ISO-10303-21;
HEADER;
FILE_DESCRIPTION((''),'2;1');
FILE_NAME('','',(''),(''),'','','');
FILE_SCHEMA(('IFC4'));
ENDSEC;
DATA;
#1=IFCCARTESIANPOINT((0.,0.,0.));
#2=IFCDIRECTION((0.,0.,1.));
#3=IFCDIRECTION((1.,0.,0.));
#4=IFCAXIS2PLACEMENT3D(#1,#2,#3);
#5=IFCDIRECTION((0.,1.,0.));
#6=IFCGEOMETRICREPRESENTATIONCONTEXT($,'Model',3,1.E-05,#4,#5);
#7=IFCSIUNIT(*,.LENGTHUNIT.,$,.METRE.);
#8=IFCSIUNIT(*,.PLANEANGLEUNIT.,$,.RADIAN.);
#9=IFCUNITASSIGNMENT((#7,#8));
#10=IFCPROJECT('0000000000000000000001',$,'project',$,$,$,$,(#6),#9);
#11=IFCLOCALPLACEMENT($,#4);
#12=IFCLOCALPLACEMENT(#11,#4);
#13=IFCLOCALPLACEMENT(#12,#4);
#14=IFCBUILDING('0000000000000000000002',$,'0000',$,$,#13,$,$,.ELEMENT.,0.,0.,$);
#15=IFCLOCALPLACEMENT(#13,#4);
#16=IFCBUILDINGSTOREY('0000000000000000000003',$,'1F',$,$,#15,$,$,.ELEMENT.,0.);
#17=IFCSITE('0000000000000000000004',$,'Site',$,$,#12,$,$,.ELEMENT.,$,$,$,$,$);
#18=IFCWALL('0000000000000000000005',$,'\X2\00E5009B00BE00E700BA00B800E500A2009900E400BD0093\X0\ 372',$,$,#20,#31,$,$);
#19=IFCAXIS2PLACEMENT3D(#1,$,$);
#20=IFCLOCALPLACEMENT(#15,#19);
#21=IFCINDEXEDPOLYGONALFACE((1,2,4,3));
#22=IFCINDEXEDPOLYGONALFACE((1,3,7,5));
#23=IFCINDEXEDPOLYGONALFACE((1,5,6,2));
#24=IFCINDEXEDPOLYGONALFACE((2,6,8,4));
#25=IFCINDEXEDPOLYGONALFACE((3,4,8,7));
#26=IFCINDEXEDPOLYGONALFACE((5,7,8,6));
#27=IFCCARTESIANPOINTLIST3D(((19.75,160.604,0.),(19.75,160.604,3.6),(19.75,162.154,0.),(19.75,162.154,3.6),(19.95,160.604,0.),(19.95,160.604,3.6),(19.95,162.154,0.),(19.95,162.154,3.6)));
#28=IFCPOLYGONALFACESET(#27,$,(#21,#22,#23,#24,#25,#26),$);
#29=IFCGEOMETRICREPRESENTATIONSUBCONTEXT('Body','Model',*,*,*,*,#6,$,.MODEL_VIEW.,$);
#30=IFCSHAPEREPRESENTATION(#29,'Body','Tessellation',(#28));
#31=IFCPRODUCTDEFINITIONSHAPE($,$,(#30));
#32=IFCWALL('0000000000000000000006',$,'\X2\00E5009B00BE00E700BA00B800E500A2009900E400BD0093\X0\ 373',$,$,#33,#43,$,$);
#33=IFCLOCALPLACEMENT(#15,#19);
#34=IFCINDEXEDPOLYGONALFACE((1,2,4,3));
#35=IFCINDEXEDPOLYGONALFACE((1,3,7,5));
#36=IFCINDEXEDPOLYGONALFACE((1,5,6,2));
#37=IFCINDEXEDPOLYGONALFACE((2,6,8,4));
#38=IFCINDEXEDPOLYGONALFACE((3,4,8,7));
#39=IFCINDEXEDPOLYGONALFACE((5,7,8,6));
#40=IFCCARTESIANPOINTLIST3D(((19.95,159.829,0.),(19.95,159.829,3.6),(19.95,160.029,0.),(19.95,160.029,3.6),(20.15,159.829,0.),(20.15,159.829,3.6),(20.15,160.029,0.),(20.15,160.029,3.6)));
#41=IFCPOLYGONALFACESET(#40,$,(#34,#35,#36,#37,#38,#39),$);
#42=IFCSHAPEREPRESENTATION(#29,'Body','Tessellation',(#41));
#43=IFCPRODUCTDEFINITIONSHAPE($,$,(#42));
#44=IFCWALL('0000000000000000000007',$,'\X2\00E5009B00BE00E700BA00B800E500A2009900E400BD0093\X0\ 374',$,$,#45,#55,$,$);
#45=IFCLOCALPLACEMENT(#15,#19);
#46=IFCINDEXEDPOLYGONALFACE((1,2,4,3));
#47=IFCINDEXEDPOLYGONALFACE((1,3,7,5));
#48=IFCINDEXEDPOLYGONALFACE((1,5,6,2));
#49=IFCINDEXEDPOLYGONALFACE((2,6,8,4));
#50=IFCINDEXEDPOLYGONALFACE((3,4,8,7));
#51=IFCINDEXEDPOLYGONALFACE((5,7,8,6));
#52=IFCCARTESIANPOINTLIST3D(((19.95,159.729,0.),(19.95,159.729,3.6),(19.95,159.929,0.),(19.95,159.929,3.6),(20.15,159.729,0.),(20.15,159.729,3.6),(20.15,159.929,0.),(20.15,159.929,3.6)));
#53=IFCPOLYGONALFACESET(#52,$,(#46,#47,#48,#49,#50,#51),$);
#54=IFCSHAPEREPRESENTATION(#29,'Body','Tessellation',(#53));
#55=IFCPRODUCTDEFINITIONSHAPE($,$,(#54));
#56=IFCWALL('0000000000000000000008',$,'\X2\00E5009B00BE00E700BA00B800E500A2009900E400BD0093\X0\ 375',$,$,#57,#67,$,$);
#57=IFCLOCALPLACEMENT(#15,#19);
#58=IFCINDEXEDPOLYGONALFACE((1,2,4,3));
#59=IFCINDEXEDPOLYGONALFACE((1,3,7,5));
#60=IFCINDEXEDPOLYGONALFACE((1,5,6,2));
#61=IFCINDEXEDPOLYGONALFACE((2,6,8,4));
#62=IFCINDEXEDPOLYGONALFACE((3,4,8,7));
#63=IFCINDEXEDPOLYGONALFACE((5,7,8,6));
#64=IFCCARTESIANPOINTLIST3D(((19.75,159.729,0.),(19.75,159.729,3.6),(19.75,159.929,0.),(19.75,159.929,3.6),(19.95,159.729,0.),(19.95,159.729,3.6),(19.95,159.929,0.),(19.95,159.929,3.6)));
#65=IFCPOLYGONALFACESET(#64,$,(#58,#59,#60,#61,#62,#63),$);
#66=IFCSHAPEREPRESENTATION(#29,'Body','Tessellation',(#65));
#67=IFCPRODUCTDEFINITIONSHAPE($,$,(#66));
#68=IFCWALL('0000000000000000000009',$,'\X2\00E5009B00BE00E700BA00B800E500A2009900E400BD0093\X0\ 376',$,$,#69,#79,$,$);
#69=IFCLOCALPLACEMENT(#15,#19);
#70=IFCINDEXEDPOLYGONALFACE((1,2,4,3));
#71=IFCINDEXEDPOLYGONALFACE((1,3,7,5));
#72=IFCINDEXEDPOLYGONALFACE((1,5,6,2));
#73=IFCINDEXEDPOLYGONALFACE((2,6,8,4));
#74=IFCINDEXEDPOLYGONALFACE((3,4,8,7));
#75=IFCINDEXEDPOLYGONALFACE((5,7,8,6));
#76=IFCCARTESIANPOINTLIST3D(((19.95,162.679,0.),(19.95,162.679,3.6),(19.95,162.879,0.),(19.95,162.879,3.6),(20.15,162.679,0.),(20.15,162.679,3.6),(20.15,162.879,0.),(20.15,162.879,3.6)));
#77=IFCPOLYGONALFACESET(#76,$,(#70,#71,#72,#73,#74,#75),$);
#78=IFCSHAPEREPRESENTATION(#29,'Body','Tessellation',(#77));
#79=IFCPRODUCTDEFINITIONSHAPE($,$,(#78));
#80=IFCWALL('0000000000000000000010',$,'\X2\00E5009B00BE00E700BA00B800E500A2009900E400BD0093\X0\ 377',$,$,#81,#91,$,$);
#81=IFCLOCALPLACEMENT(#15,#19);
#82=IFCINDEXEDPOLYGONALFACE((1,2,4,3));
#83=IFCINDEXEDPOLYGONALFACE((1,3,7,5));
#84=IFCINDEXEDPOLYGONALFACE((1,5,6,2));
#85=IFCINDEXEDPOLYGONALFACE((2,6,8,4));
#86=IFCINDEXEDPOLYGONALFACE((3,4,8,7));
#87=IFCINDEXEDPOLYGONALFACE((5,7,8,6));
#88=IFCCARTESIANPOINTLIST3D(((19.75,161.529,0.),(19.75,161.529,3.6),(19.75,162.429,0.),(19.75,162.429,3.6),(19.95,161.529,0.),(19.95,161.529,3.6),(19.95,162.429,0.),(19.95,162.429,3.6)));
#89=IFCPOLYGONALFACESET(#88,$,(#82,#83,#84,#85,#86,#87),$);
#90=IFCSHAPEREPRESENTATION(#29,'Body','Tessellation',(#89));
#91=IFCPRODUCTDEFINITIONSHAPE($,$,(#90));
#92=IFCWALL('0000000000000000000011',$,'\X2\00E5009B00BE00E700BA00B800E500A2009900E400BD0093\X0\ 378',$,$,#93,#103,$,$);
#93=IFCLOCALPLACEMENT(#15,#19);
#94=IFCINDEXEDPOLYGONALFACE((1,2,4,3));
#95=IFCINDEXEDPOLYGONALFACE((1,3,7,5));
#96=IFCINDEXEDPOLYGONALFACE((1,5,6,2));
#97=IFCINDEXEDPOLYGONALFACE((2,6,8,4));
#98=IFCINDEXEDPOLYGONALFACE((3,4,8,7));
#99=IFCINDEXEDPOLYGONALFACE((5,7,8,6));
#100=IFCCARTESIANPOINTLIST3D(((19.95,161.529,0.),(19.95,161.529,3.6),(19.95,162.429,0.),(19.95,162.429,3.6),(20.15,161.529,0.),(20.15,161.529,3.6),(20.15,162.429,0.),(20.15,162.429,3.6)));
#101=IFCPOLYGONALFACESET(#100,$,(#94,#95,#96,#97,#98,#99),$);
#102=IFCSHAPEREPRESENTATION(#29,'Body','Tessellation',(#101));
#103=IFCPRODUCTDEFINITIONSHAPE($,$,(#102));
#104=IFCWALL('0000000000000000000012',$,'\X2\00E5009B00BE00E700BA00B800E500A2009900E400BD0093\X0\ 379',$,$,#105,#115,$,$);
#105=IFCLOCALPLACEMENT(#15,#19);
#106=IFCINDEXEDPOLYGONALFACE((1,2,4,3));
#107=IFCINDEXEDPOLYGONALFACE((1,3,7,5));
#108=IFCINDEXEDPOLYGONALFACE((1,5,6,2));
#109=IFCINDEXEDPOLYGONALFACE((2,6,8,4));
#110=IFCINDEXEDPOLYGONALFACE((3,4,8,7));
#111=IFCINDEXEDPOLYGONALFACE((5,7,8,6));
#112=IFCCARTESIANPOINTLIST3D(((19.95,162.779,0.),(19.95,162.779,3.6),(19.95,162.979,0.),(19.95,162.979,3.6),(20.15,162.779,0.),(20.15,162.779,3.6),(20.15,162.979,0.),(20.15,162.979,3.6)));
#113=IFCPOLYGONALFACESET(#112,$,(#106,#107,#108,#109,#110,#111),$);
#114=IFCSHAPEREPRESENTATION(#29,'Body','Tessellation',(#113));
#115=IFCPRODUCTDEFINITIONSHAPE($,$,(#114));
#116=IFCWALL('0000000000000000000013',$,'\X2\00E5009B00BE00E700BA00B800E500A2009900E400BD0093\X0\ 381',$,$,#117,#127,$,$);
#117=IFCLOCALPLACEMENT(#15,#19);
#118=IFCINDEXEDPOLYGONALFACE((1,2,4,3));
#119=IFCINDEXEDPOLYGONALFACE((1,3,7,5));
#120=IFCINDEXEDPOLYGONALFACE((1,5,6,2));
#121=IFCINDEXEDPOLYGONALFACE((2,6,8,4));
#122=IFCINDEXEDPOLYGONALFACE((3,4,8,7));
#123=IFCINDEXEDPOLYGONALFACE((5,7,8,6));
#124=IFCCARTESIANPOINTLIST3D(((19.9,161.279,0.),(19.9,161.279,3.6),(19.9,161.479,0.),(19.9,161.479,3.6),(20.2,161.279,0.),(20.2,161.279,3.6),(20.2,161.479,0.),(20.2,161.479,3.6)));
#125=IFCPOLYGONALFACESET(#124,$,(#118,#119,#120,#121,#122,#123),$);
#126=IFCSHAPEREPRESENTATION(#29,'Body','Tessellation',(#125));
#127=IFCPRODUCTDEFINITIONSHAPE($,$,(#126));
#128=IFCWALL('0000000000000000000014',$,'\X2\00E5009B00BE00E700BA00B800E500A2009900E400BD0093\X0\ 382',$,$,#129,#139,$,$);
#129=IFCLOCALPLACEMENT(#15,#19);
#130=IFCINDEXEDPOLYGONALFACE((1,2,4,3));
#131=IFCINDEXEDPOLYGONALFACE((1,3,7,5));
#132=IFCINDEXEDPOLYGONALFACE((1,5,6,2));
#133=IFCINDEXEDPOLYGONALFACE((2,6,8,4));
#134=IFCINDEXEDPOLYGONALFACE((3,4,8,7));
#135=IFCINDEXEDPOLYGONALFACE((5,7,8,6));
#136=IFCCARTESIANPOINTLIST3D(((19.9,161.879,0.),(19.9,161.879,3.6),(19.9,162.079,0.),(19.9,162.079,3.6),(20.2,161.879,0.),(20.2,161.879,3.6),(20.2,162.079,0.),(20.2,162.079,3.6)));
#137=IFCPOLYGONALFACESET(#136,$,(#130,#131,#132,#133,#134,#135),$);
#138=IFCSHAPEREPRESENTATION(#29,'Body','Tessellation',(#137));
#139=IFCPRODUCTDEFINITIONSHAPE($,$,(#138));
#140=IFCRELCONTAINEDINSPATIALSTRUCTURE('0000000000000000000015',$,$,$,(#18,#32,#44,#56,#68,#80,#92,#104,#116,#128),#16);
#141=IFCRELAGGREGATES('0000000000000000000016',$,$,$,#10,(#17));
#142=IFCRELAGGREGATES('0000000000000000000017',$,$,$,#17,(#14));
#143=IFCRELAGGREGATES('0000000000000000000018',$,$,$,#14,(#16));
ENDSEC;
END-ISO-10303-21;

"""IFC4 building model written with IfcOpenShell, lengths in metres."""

from ifc_helpers import new_model, si_unit, direction, frame, frame_2d, origin_with_axes, place, context, subcontext, project, spatial, rectangle, extrude, element, save


model = new_model("IFC4")

# Units and contexts
model_context = context("Model", 3, precision=1e-05, world=origin_with_axes(), true_north=direction((0.0, 1.0, 0.0)))
body_context = subcontext(model_context, "Body", "Model", "MODEL_VIEW")
ifc_project = project(units=[si_unit("LENGTHUNIT", "METRE"), si_unit("PLANEANGLEUNIT", "RADIAN")], contexts=[model_context])

# Site, building, storey
placement = place(None, origin_with_axes())
site_placement = place(placement, origin_with_axes())
site = spatial("IfcSite", under=ifc_project, at=site_placement, Name="Site", CompositionType="ELEMENT")
building_placement = place(site_placement, origin_with_axes())
building = spatial("IfcBuilding", under=site, at=building_placement, Name="0000", CompositionType="ELEMENT", ElevationOfRefHeight=0.0, ElevationOfTerrain=0.0)
storey_placement = place(building_placement, origin_with_axes())
storey = spatial("IfcBuildingStorey", under=building, at=storey_placement, Name="1F", CompositionType="ELEMENT", Elevation=0.0)

# Walls
wall_1_placement = place(storey_placement, frame((19.85, 161.379, 0.0), z_axis=(0.0, 0.0, 1.0), x_axis=(0.0, -1.0, 0.0)))
element("IfcWall", 1, at=wall_1_placement, inside=storey, Name="å\u009b¾çº¸å¢\u0099ä½\u0093 372", context=body_context, shape_type="SweptSolid", body=[
    extrude(rectangle(XDim=1.55, YDim=0.2, at=frame_2d((0.0, 0.0), x_axis=(1.0, 0.0, 0.0))), frame((0.0, 0.0, 0.0), z_axis=(0.0, 0.0, 1.0)), (0.0, 0.0, 1.0), 3.6),
])
for number, where, z_axis, x_axis, name in (
    (2, (20.05, 159.929, 0.0), (0.0, 0.0, 1.0), (-1.0, 0.0, 0.0), "å\u009b¾çº¸å¢\u0099ä½\u0093 373"),
    (3, (20.05, 159.829, 0.0), (0.0, 0.0, 1.0), (-1.0, 0.0, 0.0), "å\u009b¾çº¸å¢\u0099ä½\u0093 374"),
    (4, (19.85, 159.829, 0.0), (0.0, 0.0, 1.0), (1.0, 0.0, 0.0), "å\u009b¾çº¸å¢\u0099ä½\u0093 375"),
    (5, (20.05, 162.779, 0.0), (0.0, 0.0, 1.0), (-1.0, 0.0, 0.0), "å\u009b¾çº¸å¢\u0099ä½\u0093 376"),
):
    element("IfcWall", number, at=place(storey_placement, frame(where, z_axis=z_axis, x_axis=x_axis)), inside=storey, Name=name, context=body_context, shape_type="SweptSolid", body=[
        extrude(rectangle(XDim=0.2, YDim=0.2, at=frame_2d((0.0, 0.0), x_axis=(1.0, 0.0, 0.0))), frame((0.0, 0.0, 0.0), z_axis=(0.0, 0.0, 1.0)), (0.0, 0.0, 1.0), 3.6),
    ])
for number, where, z_axis, x_axis, name in (
    (6, (19.85, 161.979, 0.0), (0.0, 0.0, 1.0), (0.0, 1.0, 0.0), "å\u009b¾çº¸å¢\u0099ä½\u0093 377"),
    (7, (20.05, 161.979, 0.0), (0.0, 0.0, 1.0), (0.0, 1.0, 0.0), "å\u009b¾çº¸å¢\u0099ä½\u0093 378"),
):
    element("IfcWall", number, at=place(storey_placement, frame(where, z_axis=z_axis, x_axis=x_axis)), inside=storey, Name=name, context=body_context, shape_type="SweptSolid", body=[
        extrude(rectangle(XDim=0.9, YDim=0.2, at=frame_2d((0.0, 0.0), x_axis=(1.0, 0.0, 0.0))), frame((0.0, 0.0, 0.0), z_axis=(0.0, 0.0, 1.0)), (0.0, 0.0, 1.0), 3.6),
    ])
wall_2_placement = place(storey_placement, frame((20.05, 162.879, 0.0), z_axis=(0.0, 0.0, 1.0), x_axis=(-1.0, 0.0, 0.0)))
element("IfcWall", 8, at=wall_2_placement, inside=storey, Name="å\u009b¾çº¸å¢\u0099ä½\u0093 379", context=body_context, shape_type="SweptSolid", body=[
    extrude(rectangle(XDim=0.2, YDim=0.2, at=frame_2d((0.0, 0.0), x_axis=(1.0, 0.0, 0.0))), frame((0.0, 0.0, 0.0), z_axis=(0.0, 0.0, 1.0)), (0.0, 0.0, 1.0), 3.6),
])
for number, where, z_axis, x_axis, name in (
    (9, (20.05, 161.379, 0.0), (0.0, 0.0, 1.0), (-1.0, 0.0, 0.0), "å\u009b¾çº¸å¢\u0099ä½\u0093 381"),
    (10, (20.05, 161.979, 0.0), (0.0, 0.0, 1.0), (-1.0, 0.0, 0.0), "å\u009b¾çº¸å¢\u0099ä½\u0093 382"),
):
    element("IfcWall", number, at=place(storey_placement, frame(where, z_axis=z_axis, x_axis=x_axis)), inside=storey, Name=name, context=body_context, shape_type="SweptSolid", body=[
        extrude(rectangle(XDim=0.3, YDim=0.2, at=frame_2d((0.0, 0.0), x_axis=(1.0, 0.0, 0.0))), frame((0.0, 0.0, 0.0), z_axis=(0.0, 0.0, 1.0)), (0.0, 0.0, 1.0), 3.6),
    ])

save(model, "model.ifc")
